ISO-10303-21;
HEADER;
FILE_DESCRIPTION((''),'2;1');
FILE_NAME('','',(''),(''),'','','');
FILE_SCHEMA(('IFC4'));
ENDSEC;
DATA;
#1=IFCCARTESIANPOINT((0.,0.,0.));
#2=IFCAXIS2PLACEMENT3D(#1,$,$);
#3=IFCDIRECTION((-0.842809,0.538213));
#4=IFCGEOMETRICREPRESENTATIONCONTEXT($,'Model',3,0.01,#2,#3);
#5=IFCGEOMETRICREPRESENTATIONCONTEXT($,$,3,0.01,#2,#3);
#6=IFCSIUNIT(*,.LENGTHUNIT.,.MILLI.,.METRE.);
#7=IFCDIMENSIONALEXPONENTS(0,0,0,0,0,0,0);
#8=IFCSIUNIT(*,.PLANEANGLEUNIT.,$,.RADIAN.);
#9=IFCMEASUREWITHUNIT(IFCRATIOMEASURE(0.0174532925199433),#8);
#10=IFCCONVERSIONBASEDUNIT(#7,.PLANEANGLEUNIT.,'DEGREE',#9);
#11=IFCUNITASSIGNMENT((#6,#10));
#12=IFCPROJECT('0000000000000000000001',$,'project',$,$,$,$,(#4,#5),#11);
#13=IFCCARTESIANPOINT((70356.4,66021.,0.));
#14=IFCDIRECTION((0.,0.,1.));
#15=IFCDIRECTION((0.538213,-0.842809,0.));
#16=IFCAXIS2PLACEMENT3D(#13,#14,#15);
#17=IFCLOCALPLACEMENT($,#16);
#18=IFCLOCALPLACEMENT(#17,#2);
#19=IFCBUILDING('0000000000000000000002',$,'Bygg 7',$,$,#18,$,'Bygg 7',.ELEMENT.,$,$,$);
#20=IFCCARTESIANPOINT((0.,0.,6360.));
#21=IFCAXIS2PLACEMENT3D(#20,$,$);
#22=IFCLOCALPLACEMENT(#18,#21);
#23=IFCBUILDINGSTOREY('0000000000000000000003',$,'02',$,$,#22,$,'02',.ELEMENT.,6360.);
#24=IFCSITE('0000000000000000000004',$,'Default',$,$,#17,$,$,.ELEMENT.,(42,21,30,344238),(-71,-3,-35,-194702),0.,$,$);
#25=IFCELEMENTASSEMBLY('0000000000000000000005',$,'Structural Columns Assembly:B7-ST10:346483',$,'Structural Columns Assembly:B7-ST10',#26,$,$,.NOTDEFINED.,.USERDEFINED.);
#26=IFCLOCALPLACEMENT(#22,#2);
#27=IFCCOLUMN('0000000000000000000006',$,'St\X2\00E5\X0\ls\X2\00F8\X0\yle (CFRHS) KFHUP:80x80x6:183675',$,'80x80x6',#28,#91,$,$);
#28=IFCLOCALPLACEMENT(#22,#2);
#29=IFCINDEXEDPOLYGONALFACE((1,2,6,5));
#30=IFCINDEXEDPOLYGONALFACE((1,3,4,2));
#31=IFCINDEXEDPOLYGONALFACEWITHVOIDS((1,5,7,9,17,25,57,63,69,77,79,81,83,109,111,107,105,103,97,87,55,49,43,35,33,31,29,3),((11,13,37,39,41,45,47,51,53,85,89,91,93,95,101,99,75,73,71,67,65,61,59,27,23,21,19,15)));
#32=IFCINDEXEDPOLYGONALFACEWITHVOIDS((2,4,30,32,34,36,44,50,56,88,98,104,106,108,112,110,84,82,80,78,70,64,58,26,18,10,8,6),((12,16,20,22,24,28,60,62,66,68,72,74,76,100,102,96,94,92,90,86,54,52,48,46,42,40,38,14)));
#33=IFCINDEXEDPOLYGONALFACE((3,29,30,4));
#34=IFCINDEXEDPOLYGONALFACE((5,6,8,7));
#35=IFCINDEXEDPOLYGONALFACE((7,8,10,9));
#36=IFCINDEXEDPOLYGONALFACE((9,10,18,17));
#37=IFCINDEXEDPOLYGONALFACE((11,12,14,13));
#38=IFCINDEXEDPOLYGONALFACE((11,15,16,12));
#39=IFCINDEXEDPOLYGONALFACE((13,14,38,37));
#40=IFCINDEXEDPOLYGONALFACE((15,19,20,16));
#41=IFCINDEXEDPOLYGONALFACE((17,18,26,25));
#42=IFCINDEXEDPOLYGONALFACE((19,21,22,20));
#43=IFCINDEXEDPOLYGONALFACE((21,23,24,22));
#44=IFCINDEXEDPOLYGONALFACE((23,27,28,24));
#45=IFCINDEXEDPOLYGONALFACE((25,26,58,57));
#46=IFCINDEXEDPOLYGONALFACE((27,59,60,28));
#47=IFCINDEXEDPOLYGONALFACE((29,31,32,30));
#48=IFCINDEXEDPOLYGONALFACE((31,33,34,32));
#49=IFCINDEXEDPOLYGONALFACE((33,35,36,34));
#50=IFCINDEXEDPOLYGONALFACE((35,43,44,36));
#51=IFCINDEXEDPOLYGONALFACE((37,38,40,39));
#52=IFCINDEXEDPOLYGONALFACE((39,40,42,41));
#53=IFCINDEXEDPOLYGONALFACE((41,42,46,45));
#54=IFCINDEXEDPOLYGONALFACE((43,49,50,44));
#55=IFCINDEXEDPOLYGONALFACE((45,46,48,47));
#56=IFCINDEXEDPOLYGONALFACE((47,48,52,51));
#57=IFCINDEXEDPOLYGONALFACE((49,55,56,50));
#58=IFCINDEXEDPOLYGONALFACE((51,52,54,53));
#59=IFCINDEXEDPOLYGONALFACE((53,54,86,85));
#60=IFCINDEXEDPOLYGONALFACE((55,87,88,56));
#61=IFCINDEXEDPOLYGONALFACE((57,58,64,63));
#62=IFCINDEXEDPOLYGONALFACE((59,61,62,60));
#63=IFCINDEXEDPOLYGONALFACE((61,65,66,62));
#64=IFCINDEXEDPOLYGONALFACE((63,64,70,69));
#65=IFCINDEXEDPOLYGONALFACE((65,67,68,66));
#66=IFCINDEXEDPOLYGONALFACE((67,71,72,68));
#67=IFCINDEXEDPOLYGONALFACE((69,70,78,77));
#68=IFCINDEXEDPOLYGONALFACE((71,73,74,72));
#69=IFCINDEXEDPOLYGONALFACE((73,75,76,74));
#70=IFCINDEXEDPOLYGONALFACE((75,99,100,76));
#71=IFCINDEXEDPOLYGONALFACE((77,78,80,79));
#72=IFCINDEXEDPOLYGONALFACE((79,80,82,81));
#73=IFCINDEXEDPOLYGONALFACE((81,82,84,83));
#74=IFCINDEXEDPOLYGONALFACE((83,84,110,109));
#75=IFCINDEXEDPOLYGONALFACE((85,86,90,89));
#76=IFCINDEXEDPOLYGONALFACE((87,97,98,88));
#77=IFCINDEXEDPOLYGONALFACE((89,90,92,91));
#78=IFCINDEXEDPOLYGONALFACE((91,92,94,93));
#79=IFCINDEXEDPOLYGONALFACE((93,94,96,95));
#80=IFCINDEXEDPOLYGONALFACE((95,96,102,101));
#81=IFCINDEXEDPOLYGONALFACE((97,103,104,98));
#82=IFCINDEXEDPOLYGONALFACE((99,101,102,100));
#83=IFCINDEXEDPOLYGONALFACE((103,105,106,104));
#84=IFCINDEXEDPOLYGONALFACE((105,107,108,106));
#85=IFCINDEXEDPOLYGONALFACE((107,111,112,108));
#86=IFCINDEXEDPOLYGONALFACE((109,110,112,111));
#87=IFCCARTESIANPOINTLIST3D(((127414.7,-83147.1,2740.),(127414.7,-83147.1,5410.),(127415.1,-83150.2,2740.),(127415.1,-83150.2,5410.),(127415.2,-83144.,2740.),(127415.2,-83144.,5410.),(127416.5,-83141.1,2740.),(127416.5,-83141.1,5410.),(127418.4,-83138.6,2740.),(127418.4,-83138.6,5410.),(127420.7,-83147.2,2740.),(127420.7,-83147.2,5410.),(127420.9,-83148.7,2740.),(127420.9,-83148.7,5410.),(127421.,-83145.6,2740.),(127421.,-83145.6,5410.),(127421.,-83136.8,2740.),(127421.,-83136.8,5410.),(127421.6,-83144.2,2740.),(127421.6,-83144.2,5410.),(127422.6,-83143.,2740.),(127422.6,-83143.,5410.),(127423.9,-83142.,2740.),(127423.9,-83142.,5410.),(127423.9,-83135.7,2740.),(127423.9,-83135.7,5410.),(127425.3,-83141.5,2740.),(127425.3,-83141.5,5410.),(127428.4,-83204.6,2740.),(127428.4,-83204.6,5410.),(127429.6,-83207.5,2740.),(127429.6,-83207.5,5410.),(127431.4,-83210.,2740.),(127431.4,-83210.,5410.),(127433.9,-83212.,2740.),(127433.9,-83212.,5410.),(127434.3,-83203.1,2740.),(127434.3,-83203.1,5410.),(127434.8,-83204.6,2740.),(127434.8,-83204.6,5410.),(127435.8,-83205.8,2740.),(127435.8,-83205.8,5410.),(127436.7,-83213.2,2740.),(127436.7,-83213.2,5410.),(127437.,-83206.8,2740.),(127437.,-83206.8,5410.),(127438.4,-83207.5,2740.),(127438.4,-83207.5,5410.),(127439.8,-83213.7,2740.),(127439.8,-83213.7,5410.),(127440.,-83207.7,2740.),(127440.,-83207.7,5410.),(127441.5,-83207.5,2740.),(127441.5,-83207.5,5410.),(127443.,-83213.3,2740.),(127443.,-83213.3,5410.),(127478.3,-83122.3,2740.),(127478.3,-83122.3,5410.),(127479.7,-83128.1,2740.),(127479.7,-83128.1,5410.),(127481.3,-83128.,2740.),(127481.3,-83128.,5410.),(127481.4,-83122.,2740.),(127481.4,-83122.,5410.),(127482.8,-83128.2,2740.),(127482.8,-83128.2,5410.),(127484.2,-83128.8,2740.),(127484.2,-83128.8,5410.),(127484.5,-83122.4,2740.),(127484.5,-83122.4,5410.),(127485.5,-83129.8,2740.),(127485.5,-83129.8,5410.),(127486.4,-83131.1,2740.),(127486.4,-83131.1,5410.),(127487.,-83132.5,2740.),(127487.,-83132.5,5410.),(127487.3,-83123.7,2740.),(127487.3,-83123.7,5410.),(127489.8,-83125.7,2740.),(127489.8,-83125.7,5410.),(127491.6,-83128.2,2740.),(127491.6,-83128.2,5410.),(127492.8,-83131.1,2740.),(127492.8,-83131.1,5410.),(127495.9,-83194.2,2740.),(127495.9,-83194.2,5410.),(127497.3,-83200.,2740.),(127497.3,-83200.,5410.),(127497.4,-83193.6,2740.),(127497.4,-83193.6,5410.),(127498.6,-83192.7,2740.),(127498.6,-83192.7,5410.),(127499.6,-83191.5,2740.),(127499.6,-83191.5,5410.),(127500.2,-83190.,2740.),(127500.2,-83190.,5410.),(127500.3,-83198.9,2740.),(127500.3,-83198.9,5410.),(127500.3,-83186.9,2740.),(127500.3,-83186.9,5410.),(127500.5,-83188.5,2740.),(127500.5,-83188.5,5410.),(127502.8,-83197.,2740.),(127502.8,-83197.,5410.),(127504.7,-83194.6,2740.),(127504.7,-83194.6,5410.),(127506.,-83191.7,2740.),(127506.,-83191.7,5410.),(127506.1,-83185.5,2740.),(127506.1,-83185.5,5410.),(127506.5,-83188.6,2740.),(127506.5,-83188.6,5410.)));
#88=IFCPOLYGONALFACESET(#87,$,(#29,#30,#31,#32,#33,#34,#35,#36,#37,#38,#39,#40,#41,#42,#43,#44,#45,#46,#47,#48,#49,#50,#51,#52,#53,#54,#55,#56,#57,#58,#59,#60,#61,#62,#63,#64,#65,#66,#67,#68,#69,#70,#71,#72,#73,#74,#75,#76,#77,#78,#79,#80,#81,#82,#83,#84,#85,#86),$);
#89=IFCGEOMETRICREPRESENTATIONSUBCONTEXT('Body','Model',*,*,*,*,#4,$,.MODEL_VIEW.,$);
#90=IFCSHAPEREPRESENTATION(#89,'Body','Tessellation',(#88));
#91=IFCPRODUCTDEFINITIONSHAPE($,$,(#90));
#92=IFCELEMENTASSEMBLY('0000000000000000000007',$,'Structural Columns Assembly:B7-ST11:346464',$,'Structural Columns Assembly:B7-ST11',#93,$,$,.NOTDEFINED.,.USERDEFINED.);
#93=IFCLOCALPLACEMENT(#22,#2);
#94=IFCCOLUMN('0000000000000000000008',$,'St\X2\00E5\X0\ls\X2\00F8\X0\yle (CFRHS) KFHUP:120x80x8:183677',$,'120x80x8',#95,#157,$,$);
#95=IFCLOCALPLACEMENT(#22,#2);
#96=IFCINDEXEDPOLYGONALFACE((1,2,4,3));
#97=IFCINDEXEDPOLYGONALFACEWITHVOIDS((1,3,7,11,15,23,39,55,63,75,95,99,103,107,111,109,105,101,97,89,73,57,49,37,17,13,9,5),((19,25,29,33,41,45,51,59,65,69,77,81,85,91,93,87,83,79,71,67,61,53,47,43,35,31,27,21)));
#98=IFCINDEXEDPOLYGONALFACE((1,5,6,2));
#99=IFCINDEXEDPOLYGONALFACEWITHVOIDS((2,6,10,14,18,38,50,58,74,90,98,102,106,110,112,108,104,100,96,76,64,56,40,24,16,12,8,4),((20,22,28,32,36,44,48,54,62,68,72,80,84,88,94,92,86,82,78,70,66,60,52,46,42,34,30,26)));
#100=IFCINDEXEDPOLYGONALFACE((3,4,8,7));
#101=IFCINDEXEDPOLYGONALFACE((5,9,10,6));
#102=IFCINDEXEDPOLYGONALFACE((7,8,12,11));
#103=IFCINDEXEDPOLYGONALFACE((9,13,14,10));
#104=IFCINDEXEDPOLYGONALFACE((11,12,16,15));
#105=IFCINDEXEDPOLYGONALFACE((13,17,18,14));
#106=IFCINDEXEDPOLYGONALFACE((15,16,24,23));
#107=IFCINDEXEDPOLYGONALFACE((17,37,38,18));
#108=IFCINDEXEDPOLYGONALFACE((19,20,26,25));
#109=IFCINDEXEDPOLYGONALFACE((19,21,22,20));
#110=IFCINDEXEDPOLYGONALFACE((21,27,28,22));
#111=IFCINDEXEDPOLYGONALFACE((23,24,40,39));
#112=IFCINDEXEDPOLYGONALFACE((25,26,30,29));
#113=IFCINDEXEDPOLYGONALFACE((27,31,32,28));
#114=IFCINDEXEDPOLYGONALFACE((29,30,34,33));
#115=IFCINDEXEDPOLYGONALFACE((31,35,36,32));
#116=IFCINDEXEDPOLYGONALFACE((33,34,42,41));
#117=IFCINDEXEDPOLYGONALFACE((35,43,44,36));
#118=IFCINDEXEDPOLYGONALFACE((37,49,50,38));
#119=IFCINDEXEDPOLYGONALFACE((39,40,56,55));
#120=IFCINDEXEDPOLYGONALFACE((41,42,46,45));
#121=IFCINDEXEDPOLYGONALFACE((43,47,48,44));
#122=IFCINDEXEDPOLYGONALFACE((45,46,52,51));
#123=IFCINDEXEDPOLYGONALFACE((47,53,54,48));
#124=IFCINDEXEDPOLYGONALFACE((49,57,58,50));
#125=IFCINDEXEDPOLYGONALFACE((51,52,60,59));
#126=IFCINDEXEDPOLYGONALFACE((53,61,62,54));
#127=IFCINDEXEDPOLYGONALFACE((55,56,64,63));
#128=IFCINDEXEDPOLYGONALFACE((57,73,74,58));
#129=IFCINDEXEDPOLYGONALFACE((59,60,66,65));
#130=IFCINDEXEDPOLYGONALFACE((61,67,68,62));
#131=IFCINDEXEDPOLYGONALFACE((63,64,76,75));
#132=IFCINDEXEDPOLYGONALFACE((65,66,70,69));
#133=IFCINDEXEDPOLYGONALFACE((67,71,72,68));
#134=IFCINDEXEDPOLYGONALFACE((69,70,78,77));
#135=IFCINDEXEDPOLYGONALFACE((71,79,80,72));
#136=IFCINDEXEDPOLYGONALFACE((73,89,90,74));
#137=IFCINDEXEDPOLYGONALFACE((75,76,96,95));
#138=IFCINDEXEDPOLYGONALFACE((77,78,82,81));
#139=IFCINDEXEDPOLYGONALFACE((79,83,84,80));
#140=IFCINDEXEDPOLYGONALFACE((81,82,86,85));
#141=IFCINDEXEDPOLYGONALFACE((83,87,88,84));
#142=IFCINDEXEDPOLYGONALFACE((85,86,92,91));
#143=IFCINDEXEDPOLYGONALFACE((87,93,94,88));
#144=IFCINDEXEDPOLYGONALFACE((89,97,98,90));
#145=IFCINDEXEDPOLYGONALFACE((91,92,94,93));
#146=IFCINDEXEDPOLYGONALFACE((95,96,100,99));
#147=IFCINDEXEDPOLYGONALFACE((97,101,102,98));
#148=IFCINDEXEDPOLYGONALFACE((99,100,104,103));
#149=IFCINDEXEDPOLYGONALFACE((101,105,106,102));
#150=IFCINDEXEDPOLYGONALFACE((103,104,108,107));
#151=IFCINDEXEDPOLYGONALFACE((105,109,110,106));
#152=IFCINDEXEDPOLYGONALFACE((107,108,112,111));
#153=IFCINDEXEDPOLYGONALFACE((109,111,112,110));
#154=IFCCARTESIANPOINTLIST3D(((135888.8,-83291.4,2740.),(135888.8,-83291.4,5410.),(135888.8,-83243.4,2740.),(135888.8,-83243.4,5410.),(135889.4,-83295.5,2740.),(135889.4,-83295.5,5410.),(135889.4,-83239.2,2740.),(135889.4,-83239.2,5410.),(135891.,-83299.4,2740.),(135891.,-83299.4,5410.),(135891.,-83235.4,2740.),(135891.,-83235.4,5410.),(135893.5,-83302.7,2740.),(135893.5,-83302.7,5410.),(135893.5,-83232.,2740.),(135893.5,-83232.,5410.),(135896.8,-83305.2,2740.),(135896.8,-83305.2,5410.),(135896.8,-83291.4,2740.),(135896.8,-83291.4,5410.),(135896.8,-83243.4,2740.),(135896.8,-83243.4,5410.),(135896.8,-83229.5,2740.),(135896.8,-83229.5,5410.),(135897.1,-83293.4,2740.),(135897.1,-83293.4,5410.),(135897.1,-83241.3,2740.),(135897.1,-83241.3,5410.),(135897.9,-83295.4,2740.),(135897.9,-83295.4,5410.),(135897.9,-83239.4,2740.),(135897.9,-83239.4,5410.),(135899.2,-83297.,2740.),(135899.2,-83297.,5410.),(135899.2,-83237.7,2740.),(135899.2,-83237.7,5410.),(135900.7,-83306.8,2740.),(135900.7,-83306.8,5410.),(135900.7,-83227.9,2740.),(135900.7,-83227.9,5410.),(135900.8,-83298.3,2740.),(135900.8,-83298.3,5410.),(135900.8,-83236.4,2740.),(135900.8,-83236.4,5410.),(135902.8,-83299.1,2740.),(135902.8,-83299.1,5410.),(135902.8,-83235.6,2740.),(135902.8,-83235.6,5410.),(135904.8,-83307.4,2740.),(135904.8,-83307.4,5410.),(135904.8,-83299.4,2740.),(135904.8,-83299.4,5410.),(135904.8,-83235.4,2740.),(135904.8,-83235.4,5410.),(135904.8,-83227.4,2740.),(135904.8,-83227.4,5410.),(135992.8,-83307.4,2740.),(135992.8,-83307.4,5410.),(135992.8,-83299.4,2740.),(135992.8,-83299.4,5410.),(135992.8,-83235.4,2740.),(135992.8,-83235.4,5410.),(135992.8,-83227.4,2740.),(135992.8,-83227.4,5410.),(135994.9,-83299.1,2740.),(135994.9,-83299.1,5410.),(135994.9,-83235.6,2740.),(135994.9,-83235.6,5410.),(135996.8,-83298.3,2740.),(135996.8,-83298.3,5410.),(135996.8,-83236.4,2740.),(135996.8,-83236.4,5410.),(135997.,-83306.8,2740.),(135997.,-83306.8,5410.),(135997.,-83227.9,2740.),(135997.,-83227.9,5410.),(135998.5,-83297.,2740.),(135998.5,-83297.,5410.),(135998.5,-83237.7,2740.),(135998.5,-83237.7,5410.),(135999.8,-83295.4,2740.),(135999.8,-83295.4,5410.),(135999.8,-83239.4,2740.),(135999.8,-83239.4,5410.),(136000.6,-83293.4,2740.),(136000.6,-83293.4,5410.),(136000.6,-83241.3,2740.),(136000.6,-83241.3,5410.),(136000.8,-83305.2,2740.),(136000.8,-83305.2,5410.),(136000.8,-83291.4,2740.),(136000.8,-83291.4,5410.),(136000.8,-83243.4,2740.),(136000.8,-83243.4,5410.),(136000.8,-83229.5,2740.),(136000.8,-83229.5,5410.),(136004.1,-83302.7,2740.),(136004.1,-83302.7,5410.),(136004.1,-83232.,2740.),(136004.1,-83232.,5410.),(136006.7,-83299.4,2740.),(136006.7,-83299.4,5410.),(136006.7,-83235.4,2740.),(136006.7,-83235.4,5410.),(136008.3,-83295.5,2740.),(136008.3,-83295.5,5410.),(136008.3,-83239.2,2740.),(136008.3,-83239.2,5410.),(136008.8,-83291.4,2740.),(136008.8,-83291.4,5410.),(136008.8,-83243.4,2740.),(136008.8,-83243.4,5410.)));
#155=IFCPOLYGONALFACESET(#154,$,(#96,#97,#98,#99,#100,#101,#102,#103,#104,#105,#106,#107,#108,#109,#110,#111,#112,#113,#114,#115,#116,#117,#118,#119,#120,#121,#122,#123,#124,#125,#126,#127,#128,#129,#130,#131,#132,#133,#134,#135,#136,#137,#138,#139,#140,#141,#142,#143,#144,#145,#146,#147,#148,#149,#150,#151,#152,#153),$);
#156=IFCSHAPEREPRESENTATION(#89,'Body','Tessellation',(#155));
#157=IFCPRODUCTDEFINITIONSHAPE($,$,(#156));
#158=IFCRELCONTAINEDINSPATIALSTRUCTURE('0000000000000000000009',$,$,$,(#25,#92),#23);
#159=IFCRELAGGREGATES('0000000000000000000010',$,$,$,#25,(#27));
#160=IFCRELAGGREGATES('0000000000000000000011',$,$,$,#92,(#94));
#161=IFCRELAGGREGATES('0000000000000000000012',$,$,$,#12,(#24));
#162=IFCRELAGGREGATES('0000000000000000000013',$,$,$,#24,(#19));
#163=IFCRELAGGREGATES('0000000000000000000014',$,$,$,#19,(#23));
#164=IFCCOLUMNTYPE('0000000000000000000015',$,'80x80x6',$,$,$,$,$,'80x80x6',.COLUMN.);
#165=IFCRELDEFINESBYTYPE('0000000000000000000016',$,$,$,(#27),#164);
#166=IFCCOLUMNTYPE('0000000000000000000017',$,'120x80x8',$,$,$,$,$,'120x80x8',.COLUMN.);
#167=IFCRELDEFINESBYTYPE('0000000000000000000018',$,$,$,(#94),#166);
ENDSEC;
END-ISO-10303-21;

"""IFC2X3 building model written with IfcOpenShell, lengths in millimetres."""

from ifc_helpers import new_model, entity, si_unit, converted_unit, direction, frame, frame_2d, origin, place, context, subcontext, project, spatial, polyline, circle_curve, parameter, trimmed, segment, composite_curve, outline, extrude, source, transform, mapped, type_object, type_shapes, element, aggregate, save


model = new_model("IFC2X3")

# Units and contexts
model_context = context("Model", 3, precision=0.01, world=origin(), true_north=direction((-0.842809, 0.538213)))
context_of_model = context(None, 3, precision=0.01, world=origin(), true_north=direction((-0.842809, 0.538213)))
body_context = subcontext(model_context, "Body", "Model", "MODEL_VIEW")
ifc_project = project(units=[si_unit("LENGTHUNIT", "METRE", prefix="MILLI"), converted_unit("PLANEANGLEUNIT", "DEGREE", entity("IfcRatioMeasure", 0.0174532925199433), si_unit("PLANEANGLEUNIT", "RADIAN"), dimensions=[0, 0, 0, 0, 0, 0, 0])], contexts=[model_context, context_of_model])

# Site, building, storey
site_placement = place(None, frame((70356.4, 66021.0, 0.0), z_axis=(0.0, 0.0, 1.0), x_axis=(0.538213, -0.842809, 0.0)))
site = spatial("IfcSite", under=ifc_project, at=site_placement, Name="Default", CompositionType="ELEMENT", RefLatitude=(42, 21, 30, 344238), RefLongitude=(-71, -3, -35, -194702), RefElevation=0.0)
building_placement = place(site_placement, origin())
building = spatial("IfcBuilding", under=site, at=building_placement, Name="Bygg 7", LongName="Bygg 7", CompositionType="ELEMENT")
storey_placement = place(building_placement, frame((0.0, 0.0, 6360.0)))
storey = spatial("IfcBuildingStorey", under=building, at=storey_placement, Name="02", LongName="02", CompositionType="ELEMENT", Elevation=6360.0)

# Element assemblies, columns
assembly_1_placement = place(storey_placement, origin())
assembly_1 = element("IfcElementAssembly", 1, at=assembly_1_placement, inside=storey, Name="Structural Columns Assembly:B7-ST10:346483", ObjectType="Structural Columns Assembly:B7-ST10", AssemblyPlace="NOTDEFINED", PredefinedType="USERDEFINED")
column_type_1 = type_object("IfcColumnType", Name="80x80x6", ElementType="80x80x6", PredefinedType="COLUMN")
shared_shape_1 = source(origin(), body_context, "Body", "SweptSolid", [
    extrude(outline(composite_curve([segment(trimmed(circle_curve(frame_2d((-28.0, 28.0), x_axis=(1.0, 0.0)), 12.0), [parameter(90.0)], [parameter(180.0)], True, "PARAMETER"), True, "CONTINUOUS"), segment(polyline([(-40.0, 28.0), (-40.0, -28.0)]), True, "CONTINUOUS"), segment(trimmed(circle_curve(frame_2d((-28.0, -28.0), x_axis=(1.0, 0.0)), 12.0), [parameter(180.0)], [parameter(270.0)], True, "PARAMETER"), True, "CONTINUOUS"), segment(polyline([(-28.0, -40.0), (28.0, -40.0)]), True, "CONTINUOUS"), segment(trimmed(circle_curve(frame_2d((28.0, -28.0), x_axis=(1.0, 0.0)), 12.0), [parameter(270.0)], [parameter(0.0)], True, "PARAMETER"), True, "CONTINUOUS"), segment(polyline([(40.0, -28.0), (40.0, 28.0)]), True, "CONTINUOUS"), segment(trimmed(circle_curve(frame_2d((28.0, 28.0), x_axis=(1.0, 0.0)), 12.0), [parameter(0.0)], [parameter(90.0)], True, "PARAMETER"), True, "CONTINUOUS"), segment(polyline([(28.0, 40.0), (-28.0, 40.0)]), True, "CONTINUOUS")], self_intersect=False), holes=[composite_curve([segment(polyline([(-28.0, 34.0), (28.0, 34.0)]), True, "CONTINUOUS"), segment(trimmed(circle_curve(frame_2d((28.0, 28.0), x_axis=(1.0, 0.0)), 6.0), [parameter(360.0)], [parameter(90.0)], True, "PARAMETER"), False, "CONTINUOUS"), segment(polyline([(34.0, 28.0), (34.0, -28.0)]), True, "CONTINUOUS"), segment(trimmed(circle_curve(frame_2d((28.0, -28.0), x_axis=(1.0, 0.0)), 6.0), [parameter(270.0)], [parameter(360.0)], True, "PARAMETER"), False, "CONTINUOUS"), segment(polyline([(28.0, -34.0), (-28.0, -34.0)]), True, "CONTINUOUS"), segment(trimmed(circle_curve(frame_2d((-28.0, -28.0), x_axis=(1.0, 0.0)), 6.0), [parameter(180.0)], [parameter(270.0)], True, "PARAMETER"), False, "CONTINUOUS"), segment(polyline([(-34.0, -28.0), (-34.0, 28.0)]), True, "CONTINUOUS"), segment(trimmed(circle_curve(frame_2d((-28.0, 28.0), x_axis=(1.0, 0.0)), 6.0), [parameter(90.0)], [parameter(180.0)], True, "PARAMETER"), False, "CONTINUOUS")], self_intersect=False)]), frame((47.5, 47.5, 0.0), z_axis=(0.0, 0.0, 1.0), x_axis=(-0.971172, -0.238381, 0.0)), (0.0, 0.0, 1.0), 2670.0),
])
type_shapes(column_type_1, [shared_shape_1])
column_1_placement = place(assembly_1_placement, frame((127413.1, -83215.3, 2740.0)))
column_1 = element("IfcColumn", 2, at=column_1_placement, type_object=column_type_1, Name="Stålsøyle (CFRHS) KFHUP:80x80x6:183675", ObjectType="80x80x6", context=body_context, shape_type="MappedRepresentation", body=[
    mapped(shared_shape_1, transform((0.0, 0.0, 0.0), scale=1.0)),
])
aggregate(assembly_1, [column_1])
assembly_2_placement = place(storey_placement, origin())
assembly_2 = element("IfcElementAssembly", 3, at=assembly_2_placement, inside=storey, Name="Structural Columns Assembly:B7-ST11:346464", ObjectType="Structural Columns Assembly:B7-ST11", AssemblyPlace="NOTDEFINED", PredefinedType="USERDEFINED")
column_type_2 = type_object("IfcColumnType", Name="120x80x8", ElementType="120x80x8", PredefinedType="COLUMN")
shared_shape_2 = source(origin(), body_context, "Body", "SweptSolid", [
    extrude(outline(composite_curve([segment(trimmed(circle_curve(frame_2d((-24.0, 44.0), x_axis=(1.0, 0.0)), 16.0), [parameter(90.0)], [parameter(180.0)], True, "PARAMETER"), True, "CONTINUOUS"), segment(polyline([(-40.0, 44.0), (-40.0, -44.0)]), True, "CONTINUOUS"), segment(trimmed(circle_curve(frame_2d((-24.0, -44.0), x_axis=(1.0, 0.0)), 16.0), [parameter(180.0)], [parameter(270.0)], True, "PARAMETER"), True, "CONTINUOUS"), segment(polyline([(-24.0, -60.0), (24.0, -60.0)]), True, "CONTINUOUS"), segment(trimmed(circle_curve(frame_2d((24.0, -44.0), x_axis=(1.0, 0.0)), 16.0), [parameter(270.0)], [parameter(0.0)], True, "PARAMETER"), True, "CONTINUOUS"), segment(polyline([(40.0, -44.0), (40.0, 44.0)]), True, "CONTINUOUS"), segment(trimmed(circle_curve(frame_2d((24.0, 44.0), x_axis=(1.0, 0.0)), 16.0), [parameter(0.0)], [parameter(90.0)], True, "PARAMETER"), True, "CONTINUOUS"), segment(polyline([(24.0, 60.0), (-24.0, 60.0)]), True, "CONTINUOUS")], self_intersect=False), holes=[composite_curve([segment(polyline([(-24.0, 52.0), (24.0, 52.0)]), True, "CONTINUOUS"), segment(trimmed(circle_curve(frame_2d((24.0, 44.0), x_axis=(1.0, 0.0)), 8.0), [parameter(360.0)], [parameter(90.0)], True, "PARAMETER"), False, "CONTINUOUS"), segment(polyline([(32.0, 44.0), (32.0, -44.0)]), True, "CONTINUOUS"), segment(trimmed(circle_curve(frame_2d((24.0, -44.0), x_axis=(1.0, 0.0)), 8.0), [parameter(270.0)], [parameter(360.0)], True, "PARAMETER"), False, "CONTINUOUS"), segment(polyline([(24.0, -52.0), (-24.0, -52.0)]), True, "CONTINUOUS"), segment(trimmed(circle_curve(frame_2d((-24.0, -44.0), x_axis=(1.0, 0.0)), 8.0), [parameter(180.0)], [parameter(270.0)], True, "PARAMETER"), False, "CONTINUOUS"), segment(polyline([(-32.0, -44.0), (-32.0, 44.0)]), True, "CONTINUOUS"), segment(trimmed(circle_curve(frame_2d((-24.0, 44.0), x_axis=(1.0, 0.0)), 8.0), [parameter(90.0)], [parameter(180.0)], True, "PARAMETER"), False, "CONTINUOUS")], self_intersect=False)]), frame((61.6, 41.6, 0.0), z_axis=(0.0, 0.0, 1.0), x_axis=(0.0, -1.0, 0.0)), (0.0, 0.0, 1.0), 2670.0),
])
type_shapes(column_type_2, [shared_shape_2])
column_2_placement = place(assembly_2_placement, frame((135887.2, -83309.0, 2740.0)))
column_2 = element("IfcColumn", 4, at=column_2_placement, type_object=column_type_2, Name="Stålsøyle (CFRHS) KFHUP:120x80x8:183677", ObjectType="120x80x8", context=body_context, shape_type="MappedRepresentation", body=[
    mapped(shared_shape_2, transform((0.0, 0.0, 0.0), scale=1.0)),
])
aggregate(assembly_2, [column_2])

save(model, "model.ifc")
